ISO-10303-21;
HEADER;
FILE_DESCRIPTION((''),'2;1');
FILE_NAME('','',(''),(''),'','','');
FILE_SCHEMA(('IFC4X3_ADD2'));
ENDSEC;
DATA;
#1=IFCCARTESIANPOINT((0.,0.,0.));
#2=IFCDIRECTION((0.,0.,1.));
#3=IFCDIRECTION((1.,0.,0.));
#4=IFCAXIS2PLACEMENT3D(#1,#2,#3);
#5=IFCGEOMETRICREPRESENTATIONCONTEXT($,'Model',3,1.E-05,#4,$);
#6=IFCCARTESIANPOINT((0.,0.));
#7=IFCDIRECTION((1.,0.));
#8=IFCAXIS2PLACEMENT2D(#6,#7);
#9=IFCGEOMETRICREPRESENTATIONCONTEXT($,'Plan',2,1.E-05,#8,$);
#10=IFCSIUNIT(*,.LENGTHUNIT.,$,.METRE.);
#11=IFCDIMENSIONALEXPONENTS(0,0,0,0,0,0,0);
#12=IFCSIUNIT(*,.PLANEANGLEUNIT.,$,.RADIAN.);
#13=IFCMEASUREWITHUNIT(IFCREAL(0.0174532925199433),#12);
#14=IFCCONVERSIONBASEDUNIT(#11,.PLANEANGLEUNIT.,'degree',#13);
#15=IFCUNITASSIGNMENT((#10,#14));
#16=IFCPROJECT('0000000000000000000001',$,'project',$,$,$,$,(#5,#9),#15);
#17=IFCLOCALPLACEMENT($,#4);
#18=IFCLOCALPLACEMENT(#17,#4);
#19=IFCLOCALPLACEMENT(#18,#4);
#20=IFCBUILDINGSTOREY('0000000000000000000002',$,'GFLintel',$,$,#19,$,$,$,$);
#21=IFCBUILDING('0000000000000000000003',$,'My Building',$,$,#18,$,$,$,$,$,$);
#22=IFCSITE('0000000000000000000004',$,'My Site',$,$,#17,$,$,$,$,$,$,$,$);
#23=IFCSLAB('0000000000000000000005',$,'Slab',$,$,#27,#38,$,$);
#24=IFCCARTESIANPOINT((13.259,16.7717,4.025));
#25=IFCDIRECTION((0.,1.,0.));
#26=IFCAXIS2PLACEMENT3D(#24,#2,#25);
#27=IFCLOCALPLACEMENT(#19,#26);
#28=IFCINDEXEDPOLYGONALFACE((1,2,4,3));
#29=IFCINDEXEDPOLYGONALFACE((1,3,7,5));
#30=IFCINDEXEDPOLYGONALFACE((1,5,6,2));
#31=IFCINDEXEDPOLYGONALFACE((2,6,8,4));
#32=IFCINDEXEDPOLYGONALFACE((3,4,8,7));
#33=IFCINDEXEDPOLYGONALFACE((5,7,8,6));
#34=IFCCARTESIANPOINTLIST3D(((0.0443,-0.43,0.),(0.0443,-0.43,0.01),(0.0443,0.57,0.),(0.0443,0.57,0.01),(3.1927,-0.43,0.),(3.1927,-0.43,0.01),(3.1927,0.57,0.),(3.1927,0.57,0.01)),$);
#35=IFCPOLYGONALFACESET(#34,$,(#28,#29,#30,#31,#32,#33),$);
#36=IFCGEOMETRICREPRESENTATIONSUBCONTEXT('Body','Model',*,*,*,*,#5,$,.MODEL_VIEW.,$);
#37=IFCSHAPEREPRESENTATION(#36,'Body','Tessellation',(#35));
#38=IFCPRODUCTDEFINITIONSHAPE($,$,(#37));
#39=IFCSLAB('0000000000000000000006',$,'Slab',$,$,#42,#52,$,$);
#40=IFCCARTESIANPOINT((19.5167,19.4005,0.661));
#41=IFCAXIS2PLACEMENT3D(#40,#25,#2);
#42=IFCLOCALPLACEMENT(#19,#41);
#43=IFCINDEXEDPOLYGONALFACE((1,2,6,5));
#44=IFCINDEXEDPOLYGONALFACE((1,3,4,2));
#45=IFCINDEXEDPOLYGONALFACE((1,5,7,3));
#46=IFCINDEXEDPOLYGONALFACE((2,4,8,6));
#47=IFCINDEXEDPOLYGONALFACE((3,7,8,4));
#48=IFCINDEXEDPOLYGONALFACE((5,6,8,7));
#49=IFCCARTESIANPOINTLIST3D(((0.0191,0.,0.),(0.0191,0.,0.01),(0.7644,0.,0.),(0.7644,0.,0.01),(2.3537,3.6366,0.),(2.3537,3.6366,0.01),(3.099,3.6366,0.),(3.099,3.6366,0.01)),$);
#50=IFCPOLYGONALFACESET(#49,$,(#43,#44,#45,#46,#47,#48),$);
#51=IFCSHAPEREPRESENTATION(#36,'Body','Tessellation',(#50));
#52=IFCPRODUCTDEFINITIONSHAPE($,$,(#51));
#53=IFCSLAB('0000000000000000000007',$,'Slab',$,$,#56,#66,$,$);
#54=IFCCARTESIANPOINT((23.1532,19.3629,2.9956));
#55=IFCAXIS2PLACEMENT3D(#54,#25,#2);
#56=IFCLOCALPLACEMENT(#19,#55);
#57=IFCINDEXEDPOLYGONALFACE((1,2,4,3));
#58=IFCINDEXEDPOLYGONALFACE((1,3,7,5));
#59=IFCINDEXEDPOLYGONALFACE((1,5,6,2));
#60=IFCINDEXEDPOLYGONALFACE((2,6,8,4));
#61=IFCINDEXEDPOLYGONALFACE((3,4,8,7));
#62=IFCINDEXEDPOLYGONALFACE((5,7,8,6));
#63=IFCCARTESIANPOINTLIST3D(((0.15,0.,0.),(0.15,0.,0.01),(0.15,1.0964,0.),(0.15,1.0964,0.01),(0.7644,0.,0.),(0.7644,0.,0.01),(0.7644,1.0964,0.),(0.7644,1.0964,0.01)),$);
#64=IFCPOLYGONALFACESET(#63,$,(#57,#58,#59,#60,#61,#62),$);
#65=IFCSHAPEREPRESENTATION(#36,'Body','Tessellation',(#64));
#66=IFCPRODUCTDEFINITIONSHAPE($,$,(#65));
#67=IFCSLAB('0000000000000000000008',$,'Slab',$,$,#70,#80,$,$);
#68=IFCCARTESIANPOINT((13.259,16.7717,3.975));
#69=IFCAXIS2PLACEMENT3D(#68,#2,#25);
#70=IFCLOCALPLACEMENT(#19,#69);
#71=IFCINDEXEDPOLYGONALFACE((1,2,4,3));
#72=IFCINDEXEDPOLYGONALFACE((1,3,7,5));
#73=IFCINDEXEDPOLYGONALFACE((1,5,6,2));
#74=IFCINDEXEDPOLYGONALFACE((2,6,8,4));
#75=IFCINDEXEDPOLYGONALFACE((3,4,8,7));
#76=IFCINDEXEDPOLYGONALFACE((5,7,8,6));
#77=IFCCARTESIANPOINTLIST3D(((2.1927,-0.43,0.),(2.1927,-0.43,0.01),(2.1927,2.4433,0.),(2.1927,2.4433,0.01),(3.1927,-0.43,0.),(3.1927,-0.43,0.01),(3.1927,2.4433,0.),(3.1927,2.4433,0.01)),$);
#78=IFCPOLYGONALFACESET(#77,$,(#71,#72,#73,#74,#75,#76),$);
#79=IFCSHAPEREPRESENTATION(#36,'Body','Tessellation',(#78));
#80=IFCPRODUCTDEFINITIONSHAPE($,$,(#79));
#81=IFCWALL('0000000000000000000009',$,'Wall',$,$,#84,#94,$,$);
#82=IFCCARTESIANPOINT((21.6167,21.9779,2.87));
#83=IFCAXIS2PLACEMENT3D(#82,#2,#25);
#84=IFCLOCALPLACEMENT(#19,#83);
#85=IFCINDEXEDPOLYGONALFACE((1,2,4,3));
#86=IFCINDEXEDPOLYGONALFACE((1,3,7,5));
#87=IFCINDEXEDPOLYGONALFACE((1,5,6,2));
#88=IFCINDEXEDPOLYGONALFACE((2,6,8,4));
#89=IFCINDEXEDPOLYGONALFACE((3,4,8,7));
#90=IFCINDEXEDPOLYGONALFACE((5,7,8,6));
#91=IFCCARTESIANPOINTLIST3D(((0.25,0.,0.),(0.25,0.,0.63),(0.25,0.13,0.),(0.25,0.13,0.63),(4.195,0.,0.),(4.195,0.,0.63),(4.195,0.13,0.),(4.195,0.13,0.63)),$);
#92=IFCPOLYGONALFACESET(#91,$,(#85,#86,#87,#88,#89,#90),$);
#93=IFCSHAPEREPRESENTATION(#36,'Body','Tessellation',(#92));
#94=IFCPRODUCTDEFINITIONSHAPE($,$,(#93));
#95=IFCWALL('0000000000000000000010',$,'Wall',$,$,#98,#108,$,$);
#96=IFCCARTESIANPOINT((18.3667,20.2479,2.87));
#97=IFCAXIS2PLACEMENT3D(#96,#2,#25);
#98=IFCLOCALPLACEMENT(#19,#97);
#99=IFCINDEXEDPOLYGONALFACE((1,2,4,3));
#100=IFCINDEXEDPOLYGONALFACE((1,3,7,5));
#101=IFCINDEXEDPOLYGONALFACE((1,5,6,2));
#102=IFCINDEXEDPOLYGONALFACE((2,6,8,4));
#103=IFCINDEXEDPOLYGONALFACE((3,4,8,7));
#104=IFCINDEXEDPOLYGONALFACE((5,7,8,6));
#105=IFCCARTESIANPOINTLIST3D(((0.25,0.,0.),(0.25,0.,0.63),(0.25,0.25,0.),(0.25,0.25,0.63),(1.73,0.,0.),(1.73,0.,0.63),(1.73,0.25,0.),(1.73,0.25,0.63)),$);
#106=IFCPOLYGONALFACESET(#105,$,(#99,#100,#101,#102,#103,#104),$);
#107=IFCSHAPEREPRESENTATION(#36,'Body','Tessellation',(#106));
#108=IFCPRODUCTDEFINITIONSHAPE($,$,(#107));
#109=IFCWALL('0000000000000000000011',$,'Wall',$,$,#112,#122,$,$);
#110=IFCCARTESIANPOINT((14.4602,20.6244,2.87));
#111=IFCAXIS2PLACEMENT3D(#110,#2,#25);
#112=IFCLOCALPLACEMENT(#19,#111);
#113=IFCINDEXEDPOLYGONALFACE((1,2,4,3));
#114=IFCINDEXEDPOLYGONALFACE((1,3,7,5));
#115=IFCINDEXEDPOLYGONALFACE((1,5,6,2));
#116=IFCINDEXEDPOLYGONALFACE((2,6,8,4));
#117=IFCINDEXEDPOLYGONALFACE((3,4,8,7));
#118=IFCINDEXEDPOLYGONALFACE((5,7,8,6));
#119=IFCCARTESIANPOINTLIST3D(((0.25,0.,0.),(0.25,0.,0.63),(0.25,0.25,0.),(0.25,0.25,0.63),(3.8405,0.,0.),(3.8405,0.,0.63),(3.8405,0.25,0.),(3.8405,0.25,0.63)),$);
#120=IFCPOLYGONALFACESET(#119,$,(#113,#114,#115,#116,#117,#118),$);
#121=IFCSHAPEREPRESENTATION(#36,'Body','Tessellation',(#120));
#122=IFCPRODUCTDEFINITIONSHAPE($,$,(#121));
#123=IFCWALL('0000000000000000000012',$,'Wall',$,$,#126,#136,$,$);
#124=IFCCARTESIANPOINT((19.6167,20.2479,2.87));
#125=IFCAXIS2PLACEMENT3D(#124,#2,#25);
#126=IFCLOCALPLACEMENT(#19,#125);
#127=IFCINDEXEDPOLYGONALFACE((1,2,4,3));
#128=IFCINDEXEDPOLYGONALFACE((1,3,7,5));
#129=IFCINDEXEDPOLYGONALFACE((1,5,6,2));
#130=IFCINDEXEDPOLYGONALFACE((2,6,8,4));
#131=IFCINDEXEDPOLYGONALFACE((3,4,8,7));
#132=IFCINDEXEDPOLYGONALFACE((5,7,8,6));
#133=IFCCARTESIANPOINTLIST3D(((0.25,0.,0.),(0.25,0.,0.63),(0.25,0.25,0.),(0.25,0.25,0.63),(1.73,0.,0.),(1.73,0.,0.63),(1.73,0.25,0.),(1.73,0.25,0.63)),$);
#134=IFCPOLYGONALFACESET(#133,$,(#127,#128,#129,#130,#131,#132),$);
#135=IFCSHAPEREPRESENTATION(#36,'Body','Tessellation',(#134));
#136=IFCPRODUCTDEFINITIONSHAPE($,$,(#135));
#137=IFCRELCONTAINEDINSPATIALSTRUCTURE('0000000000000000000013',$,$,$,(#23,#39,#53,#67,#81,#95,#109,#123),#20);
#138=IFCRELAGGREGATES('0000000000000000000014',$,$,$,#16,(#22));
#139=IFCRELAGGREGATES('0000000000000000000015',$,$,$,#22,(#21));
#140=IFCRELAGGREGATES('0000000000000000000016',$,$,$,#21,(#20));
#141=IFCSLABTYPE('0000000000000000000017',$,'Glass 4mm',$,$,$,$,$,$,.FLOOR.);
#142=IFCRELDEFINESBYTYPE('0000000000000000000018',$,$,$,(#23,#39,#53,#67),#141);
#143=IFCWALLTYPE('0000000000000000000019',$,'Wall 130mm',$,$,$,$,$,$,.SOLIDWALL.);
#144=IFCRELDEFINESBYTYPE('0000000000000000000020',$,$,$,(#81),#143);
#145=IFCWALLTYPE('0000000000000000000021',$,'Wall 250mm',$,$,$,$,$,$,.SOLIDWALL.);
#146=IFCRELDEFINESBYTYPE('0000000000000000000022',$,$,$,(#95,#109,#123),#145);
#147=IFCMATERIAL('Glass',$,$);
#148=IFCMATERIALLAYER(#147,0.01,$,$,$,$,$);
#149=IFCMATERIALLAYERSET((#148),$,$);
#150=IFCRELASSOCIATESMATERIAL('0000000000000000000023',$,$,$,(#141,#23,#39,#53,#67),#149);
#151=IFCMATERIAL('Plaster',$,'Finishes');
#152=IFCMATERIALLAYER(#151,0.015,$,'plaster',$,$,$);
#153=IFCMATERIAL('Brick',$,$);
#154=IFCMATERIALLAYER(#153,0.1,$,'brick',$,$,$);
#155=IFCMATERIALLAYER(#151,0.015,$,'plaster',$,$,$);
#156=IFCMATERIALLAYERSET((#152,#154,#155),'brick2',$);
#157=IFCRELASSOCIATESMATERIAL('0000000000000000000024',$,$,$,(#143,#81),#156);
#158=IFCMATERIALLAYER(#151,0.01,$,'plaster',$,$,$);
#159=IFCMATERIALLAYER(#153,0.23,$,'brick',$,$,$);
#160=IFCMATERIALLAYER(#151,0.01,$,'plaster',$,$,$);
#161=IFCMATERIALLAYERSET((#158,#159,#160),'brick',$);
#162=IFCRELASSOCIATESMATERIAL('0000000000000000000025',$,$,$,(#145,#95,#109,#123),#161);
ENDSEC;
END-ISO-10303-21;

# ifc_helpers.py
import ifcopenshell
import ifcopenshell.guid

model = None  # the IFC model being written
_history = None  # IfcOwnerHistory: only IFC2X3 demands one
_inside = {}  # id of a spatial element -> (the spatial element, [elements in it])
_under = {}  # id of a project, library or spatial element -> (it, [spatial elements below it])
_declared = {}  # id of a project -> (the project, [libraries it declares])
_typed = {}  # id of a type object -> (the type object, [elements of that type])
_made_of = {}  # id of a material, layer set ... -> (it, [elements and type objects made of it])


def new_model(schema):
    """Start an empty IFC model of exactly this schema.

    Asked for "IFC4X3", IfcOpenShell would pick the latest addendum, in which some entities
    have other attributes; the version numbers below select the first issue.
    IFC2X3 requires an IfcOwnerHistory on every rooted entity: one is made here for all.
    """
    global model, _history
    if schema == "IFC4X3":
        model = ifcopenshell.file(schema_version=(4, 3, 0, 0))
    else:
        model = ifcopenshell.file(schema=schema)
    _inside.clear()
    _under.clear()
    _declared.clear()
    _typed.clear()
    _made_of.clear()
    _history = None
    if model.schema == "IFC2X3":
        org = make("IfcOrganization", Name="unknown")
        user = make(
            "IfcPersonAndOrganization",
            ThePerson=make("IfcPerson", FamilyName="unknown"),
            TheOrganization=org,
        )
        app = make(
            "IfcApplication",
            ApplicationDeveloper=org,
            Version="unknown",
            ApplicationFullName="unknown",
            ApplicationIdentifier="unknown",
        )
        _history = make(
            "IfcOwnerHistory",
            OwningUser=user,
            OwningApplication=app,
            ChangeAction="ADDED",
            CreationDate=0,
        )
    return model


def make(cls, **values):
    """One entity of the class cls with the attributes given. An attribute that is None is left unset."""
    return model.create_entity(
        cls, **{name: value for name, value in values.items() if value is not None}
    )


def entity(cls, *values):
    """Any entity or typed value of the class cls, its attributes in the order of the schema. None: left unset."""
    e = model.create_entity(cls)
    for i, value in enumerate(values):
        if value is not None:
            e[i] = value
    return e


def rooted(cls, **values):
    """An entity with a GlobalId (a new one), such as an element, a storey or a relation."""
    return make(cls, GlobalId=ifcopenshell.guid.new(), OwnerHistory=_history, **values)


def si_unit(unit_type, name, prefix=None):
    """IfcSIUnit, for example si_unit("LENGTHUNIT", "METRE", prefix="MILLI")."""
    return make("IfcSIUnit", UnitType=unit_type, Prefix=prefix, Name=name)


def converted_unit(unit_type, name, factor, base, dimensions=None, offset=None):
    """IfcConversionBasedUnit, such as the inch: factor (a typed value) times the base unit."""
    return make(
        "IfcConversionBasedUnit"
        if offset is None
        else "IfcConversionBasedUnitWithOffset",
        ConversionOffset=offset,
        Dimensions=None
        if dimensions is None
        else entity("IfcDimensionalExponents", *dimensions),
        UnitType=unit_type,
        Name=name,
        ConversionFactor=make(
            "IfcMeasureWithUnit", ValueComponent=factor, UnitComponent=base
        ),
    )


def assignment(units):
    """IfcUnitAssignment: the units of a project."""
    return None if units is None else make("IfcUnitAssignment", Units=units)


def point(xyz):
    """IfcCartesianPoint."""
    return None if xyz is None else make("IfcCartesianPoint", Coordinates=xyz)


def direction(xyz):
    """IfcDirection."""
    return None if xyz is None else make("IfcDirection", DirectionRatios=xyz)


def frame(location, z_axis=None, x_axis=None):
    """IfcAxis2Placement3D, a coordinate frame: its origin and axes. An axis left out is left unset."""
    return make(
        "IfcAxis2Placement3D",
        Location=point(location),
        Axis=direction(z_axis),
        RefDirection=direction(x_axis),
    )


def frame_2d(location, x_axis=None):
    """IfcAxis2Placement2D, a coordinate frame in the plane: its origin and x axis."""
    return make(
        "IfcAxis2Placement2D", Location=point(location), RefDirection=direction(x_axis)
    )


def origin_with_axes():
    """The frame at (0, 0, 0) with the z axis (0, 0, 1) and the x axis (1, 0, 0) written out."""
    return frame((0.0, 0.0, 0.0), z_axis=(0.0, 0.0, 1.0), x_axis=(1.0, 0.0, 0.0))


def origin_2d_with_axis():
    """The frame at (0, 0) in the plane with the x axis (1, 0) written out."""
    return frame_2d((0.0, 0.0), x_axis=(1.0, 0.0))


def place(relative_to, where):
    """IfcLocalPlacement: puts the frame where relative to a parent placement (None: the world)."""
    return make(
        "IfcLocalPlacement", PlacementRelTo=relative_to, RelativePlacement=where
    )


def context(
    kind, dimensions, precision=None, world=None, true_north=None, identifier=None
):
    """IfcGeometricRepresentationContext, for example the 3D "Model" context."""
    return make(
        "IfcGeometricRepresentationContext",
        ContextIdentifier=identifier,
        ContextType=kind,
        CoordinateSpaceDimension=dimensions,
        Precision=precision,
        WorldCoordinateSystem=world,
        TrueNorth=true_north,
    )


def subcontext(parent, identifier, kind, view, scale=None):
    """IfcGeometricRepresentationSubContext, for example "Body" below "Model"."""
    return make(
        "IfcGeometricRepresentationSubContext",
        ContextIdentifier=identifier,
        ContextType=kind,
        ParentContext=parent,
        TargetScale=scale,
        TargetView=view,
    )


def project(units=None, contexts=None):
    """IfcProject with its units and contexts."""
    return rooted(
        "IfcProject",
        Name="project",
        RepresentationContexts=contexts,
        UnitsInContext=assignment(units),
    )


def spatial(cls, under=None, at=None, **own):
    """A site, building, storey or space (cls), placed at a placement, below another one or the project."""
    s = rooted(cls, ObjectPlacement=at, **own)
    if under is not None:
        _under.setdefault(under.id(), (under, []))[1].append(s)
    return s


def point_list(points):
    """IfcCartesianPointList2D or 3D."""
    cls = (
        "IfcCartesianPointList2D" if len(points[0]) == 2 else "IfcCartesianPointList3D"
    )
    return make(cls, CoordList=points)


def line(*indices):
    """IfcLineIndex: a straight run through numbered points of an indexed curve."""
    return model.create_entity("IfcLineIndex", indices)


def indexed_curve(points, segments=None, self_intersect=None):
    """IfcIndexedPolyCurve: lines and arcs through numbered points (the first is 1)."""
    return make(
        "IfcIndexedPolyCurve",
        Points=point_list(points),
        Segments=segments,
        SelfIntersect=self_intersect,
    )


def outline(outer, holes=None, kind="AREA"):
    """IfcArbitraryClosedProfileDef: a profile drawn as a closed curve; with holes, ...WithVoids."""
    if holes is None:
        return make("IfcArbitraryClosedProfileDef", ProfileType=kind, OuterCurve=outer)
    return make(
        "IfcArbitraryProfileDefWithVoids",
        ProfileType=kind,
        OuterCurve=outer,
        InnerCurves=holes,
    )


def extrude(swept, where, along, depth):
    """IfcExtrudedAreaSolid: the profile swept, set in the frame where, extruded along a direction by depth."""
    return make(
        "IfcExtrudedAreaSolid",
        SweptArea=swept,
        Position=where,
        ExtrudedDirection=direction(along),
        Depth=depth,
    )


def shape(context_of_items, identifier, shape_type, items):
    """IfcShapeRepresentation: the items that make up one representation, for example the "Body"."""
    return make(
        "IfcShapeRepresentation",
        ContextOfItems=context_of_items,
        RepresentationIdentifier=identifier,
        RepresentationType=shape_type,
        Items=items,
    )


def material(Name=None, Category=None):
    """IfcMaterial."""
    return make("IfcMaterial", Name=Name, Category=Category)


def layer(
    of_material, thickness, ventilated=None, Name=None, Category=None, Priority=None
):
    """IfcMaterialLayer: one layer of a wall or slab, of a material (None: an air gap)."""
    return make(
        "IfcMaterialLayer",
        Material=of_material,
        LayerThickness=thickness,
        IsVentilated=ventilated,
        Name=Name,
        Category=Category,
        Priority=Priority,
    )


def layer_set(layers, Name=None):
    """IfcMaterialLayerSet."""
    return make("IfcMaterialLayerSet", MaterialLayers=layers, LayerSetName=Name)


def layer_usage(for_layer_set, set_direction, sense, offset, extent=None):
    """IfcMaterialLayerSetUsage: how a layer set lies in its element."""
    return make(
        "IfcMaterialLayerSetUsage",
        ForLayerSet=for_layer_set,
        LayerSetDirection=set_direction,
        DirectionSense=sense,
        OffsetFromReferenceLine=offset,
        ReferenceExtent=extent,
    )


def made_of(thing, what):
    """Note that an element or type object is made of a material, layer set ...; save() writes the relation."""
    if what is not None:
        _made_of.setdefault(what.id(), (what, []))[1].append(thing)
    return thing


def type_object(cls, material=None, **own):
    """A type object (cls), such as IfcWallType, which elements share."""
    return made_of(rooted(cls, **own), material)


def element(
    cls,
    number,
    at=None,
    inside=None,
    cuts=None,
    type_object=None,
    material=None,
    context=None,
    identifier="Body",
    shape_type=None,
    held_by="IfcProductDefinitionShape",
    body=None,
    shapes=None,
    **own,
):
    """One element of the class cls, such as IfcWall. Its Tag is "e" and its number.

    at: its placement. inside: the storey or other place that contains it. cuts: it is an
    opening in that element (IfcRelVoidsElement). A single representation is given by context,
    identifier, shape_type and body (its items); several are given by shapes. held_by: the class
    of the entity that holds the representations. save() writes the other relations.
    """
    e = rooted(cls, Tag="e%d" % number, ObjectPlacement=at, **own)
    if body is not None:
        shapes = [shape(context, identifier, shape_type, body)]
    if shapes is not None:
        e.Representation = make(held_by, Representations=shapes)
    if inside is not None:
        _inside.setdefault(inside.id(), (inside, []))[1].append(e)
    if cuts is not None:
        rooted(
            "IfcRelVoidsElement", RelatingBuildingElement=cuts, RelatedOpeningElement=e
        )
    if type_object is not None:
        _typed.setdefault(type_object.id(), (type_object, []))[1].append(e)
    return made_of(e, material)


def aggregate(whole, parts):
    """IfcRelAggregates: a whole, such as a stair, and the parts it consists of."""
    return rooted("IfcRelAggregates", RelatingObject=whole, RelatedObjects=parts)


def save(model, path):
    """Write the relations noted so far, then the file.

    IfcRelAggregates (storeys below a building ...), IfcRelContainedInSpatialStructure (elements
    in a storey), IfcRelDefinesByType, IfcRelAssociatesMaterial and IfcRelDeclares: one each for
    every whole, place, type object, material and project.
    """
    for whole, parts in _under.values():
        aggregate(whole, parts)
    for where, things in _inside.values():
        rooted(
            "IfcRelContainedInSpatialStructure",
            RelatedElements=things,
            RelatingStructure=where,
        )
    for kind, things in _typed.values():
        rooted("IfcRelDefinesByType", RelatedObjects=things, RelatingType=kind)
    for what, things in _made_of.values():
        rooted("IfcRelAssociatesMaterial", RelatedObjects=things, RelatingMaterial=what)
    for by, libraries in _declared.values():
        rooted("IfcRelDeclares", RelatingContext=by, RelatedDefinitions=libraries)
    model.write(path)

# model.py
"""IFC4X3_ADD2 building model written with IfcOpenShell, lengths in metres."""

from ifc_helpers import new_model, entity, si_unit, converted_unit, frame, origin_with_axes, origin_2d_with_axis, place, context, subcontext, project, spatial, line, indexed_curve, outline, extrude, material, layer, layer_set, layer_usage, type_object, element, save


model = new_model("IFC4X3_ADD2")

# Units and contexts
model_context = context("Model", 3, precision=1e-05, world=origin_with_axes())
plan_context = context("Plan", 2, precision=1e-05, world=origin_2d_with_axis())
body_context = subcontext(model_context, "Body", "Model", "MODEL_VIEW")
ifc_project = project(units=[si_unit("LENGTHUNIT", "METRE"), converted_unit("PLANEANGLEUNIT", "degree", entity("IfcReal", 0.0174532925199433), si_unit("PLANEANGLEUNIT", "RADIAN"), dimensions=[0, 0, 0, 0, 0, 0, 0])], contexts=[model_context, plan_context])

# Site, building, storey
site_placement = place(None, origin_with_axes())
site = spatial("IfcSite", under=ifc_project, at=site_placement, Name="My Site")
building_placement = place(site_placement, origin_with_axes())
building = spatial("IfcBuilding", under=site, at=building_placement, Name="My Building")
storey_placement = place(building_placement, origin_with_axes())
storey = spatial("IfcBuildingStorey", under=building, at=storey_placement, Name="GFLintel")

# Shared definitions
ifc_material_1 = material(Name="Brick")

# Slabs
ifc_material_2 = material(Name="Glass")
ifc_layer_1 = layer(ifc_material_2, 0.01)
ifc_layer_set_1 = layer_set([ifc_layer_1])
ifc_layer_usage_1 = layer_usage(ifc_layer_set_1, "AXIS3", "POSITIVE", 0.0)
slab_type = type_object("IfcSlabType", Name="Glass 4mm", PredefinedType="FLOOR", material=ifc_layer_set_1)
slab_1_placement = place(storey_placement, frame((13.259, 16.7717, 4.025), z_axis=(0.0, 0.0, 1.0), x_axis=(0.0, 1.0, 0.0)))
element("IfcSlab", 1, at=slab_1_placement, inside=storey, type_object=slab_type, material=ifc_layer_usage_1, Name="Slab", context=body_context, shape_type="SweptSolid", body=[
    extrude(outline(indexed_curve([(0.0443, 0.57), (0.0443, -0.43), (3.1927, -0.43), (3.1927, 0.57), (0.0443, 0.57)])), None, (0.0, 0.0, 1.0), 0.01),
])
ifc_layer_usage_2 = layer_usage(ifc_layer_set_1, "AXIS3", "POSITIVE", 0.0)
slab_2_placement = place(storey_placement, frame((19.5167, 19.4005, 0.661), z_axis=(0.0, 1.0, 0.0), x_axis=(0.0, 0.0, 1.0)))
element("IfcSlab", 2, at=slab_2_placement, inside=storey, type_object=slab_type, material=ifc_layer_usage_2, Name="Slab", context=body_context, shape_type="SweptSolid", body=[
    extrude(outline(indexed_curve([(2.3537, 3.6366), (3.099, 3.6366), (0.7644, 0.0), (0.0191, 0.0), (2.3537, 3.6366)])), None, (0.0, 0.0, 1.0), 0.01),
])
ifc_layer_usage_3 = layer_usage(ifc_layer_set_1, "AXIS3", "POSITIVE", 0.0)
slab_3_placement = place(storey_placement, frame((23.1532, 19.3629, 2.9956), z_axis=(0.0, 1.0, 0.0), x_axis=(0.0, 0.0, 1.0)))
element("IfcSlab", 3, at=slab_3_placement, inside=storey, type_object=slab_type, material=ifc_layer_usage_3, Name="Slab", context=body_context, shape_type="SweptSolid", body=[
    extrude(outline(indexed_curve([(0.15, 0.0), (0.7644, 0.0), (0.7644, 1.0964), (0.15, 1.0964), (0.15, 0.0)])), None, (0.0, 0.0, 1.0), 0.01),
])
ifc_layer_usage_4 = layer_usage(ifc_layer_set_1, "AXIS3", "POSITIVE", 0.0)
slab_4_placement = place(storey_placement, frame((13.259, 16.7717, 3.975), z_axis=(0.0, 0.0, 1.0), x_axis=(0.0, 1.0, 0.0)))
element("IfcSlab", 4, at=slab_4_placement, inside=storey, type_object=slab_type, material=ifc_layer_usage_4, Name="Slab", context=body_context, shape_type="SweptSolid", body=[
    extrude(outline(indexed_curve([(2.1927, -0.43), (3.1927, -0.43), (3.1927, 2.4433), (2.1927, 2.4433), (2.1927, -0.43)])), None, (0.0, 0.0, 1.0), 0.01),
])

# Walls
ifc_material_3 = material(Name="Plaster", Category="Finishes")
ifc_layer_2 = layer(ifc_material_3, 0.015, Name="plaster")
ifc_layer_3 = layer(ifc_material_1, 0.1, Name="brick")
ifc_layer_4 = layer(ifc_material_3, 0.015, Name="plaster")
ifc_layer_set_2 = layer_set([ifc_layer_2, ifc_layer_3, ifc_layer_4], Name="brick2")
wall_type_1 = type_object("IfcWallType", Name="Wall 130mm", PredefinedType="SOLIDWALL", material=ifc_layer_set_2)
ifc_layer_usage_5 = layer_usage(ifc_layer_set_2, "AXIS2", "POSITIVE", 0.0)
wall_1_placement = place(storey_placement, frame((21.6167, 21.9779, 2.87), z_axis=(0.0, 0.0, 1.0), x_axis=(0.0, 1.0, 0.0)))
element("IfcWall", 5, at=wall_1_placement, inside=storey, type_object=wall_type_1, material=ifc_layer_usage_5, Name="Wall", context=body_context, shape_type="SweptSolid", body=[
    extrude(outline(indexed_curve([(0.25, 0.0), (0.25, 0.13), (4.195, 0.13), (4.195, 0.0)], segments=[line(1, 2, 3, 4, 1)])), origin_with_axes(), (0.0, 0.0, 1.0), 0.63),
])
ifc_layer_5 = layer(ifc_material_3, 0.01, Name="plaster")
ifc_layer_6 = layer(ifc_material_1, 0.23, Name="brick")
ifc_layer_7 = layer(ifc_material_3, 0.01, Name="plaster")
ifc_layer_set_3 = layer_set([ifc_layer_5, ifc_layer_6, ifc_layer_7], Name="brick")
ifc_layer_usage_6 = layer_usage(ifc_layer_set_3, "AXIS2", "POSITIVE", 0.0)
wall_type_2 = type_object("IfcWallType", Name="Wall 250mm", PredefinedType="SOLIDWALL", material=ifc_layer_set_3)
wall_2_placement = place(storey_placement, frame((18.3667, 20.2479, 2.87), z_axis=(0.0, 0.0, 1.0), x_axis=(0.0, 1.0, 0.0)))
element("IfcWall", 6, at=wall_2_placement, inside=storey, type_object=wall_type_2, material=ifc_layer_usage_6, Name="Wall", context=body_context, shape_type="SweptSolid", body=[
    extrude(outline(indexed_curve([(0.25, 0.0), (0.25, 0.25), (1.73, 0.25), (1.73, 0.0)], segments=[line(1, 2, 3, 4, 1)])), origin_with_axes(), (0.0, 0.0, 1.0), 0.63),
])
ifc_layer_usage_7 = layer_usage(ifc_layer_set_3, "AXIS2", "POSITIVE", 0.0)
wall_3_placement = place(storey_placement, frame((14.4602, 20.6244, 2.87), z_axis=(0.0, 0.0, 1.0), x_axis=(0.0, 1.0, 0.0)))
element("IfcWall", 7, at=wall_3_placement, inside=storey, type_object=wall_type_2, material=ifc_layer_usage_7, Name="Wall", context=body_context, shape_type="SweptSolid", body=[
    extrude(outline(indexed_curve([(0.25, 0.0), (0.25, 0.25), (3.8405, 0.25), (3.8405, 0.0)], segments=[line(1, 2, 3, 4, 1)])), origin_with_axes(), (0.0, 0.0, 1.0), 0.63),
])
ifc_layer_usage_8 = layer_usage(ifc_layer_set_3, "AXIS2", "POSITIVE", 0.0)
wall_4_placement = place(storey_placement, frame((19.6167, 20.2479, 2.87), z_axis=(0.0, 0.0, 1.0), x_axis=(0.0, 1.0, 0.0)))
element("IfcWall", 8, at=wall_4_placement, inside=storey, type_object=wall_type_2, material=ifc_layer_usage_8, Name="Wall", context=body_context, shape_type="SweptSolid", body=[
    extrude(outline(indexed_curve([(0.25, 0.0), (0.25, 0.25), (1.73, 0.25), (1.73, 0.0)], segments=[line(1, 2, 3, 4, 1)])), origin_with_axes(), (0.0, 0.0, 1.0), 0.63),
])

save(model, "model.ifc")
